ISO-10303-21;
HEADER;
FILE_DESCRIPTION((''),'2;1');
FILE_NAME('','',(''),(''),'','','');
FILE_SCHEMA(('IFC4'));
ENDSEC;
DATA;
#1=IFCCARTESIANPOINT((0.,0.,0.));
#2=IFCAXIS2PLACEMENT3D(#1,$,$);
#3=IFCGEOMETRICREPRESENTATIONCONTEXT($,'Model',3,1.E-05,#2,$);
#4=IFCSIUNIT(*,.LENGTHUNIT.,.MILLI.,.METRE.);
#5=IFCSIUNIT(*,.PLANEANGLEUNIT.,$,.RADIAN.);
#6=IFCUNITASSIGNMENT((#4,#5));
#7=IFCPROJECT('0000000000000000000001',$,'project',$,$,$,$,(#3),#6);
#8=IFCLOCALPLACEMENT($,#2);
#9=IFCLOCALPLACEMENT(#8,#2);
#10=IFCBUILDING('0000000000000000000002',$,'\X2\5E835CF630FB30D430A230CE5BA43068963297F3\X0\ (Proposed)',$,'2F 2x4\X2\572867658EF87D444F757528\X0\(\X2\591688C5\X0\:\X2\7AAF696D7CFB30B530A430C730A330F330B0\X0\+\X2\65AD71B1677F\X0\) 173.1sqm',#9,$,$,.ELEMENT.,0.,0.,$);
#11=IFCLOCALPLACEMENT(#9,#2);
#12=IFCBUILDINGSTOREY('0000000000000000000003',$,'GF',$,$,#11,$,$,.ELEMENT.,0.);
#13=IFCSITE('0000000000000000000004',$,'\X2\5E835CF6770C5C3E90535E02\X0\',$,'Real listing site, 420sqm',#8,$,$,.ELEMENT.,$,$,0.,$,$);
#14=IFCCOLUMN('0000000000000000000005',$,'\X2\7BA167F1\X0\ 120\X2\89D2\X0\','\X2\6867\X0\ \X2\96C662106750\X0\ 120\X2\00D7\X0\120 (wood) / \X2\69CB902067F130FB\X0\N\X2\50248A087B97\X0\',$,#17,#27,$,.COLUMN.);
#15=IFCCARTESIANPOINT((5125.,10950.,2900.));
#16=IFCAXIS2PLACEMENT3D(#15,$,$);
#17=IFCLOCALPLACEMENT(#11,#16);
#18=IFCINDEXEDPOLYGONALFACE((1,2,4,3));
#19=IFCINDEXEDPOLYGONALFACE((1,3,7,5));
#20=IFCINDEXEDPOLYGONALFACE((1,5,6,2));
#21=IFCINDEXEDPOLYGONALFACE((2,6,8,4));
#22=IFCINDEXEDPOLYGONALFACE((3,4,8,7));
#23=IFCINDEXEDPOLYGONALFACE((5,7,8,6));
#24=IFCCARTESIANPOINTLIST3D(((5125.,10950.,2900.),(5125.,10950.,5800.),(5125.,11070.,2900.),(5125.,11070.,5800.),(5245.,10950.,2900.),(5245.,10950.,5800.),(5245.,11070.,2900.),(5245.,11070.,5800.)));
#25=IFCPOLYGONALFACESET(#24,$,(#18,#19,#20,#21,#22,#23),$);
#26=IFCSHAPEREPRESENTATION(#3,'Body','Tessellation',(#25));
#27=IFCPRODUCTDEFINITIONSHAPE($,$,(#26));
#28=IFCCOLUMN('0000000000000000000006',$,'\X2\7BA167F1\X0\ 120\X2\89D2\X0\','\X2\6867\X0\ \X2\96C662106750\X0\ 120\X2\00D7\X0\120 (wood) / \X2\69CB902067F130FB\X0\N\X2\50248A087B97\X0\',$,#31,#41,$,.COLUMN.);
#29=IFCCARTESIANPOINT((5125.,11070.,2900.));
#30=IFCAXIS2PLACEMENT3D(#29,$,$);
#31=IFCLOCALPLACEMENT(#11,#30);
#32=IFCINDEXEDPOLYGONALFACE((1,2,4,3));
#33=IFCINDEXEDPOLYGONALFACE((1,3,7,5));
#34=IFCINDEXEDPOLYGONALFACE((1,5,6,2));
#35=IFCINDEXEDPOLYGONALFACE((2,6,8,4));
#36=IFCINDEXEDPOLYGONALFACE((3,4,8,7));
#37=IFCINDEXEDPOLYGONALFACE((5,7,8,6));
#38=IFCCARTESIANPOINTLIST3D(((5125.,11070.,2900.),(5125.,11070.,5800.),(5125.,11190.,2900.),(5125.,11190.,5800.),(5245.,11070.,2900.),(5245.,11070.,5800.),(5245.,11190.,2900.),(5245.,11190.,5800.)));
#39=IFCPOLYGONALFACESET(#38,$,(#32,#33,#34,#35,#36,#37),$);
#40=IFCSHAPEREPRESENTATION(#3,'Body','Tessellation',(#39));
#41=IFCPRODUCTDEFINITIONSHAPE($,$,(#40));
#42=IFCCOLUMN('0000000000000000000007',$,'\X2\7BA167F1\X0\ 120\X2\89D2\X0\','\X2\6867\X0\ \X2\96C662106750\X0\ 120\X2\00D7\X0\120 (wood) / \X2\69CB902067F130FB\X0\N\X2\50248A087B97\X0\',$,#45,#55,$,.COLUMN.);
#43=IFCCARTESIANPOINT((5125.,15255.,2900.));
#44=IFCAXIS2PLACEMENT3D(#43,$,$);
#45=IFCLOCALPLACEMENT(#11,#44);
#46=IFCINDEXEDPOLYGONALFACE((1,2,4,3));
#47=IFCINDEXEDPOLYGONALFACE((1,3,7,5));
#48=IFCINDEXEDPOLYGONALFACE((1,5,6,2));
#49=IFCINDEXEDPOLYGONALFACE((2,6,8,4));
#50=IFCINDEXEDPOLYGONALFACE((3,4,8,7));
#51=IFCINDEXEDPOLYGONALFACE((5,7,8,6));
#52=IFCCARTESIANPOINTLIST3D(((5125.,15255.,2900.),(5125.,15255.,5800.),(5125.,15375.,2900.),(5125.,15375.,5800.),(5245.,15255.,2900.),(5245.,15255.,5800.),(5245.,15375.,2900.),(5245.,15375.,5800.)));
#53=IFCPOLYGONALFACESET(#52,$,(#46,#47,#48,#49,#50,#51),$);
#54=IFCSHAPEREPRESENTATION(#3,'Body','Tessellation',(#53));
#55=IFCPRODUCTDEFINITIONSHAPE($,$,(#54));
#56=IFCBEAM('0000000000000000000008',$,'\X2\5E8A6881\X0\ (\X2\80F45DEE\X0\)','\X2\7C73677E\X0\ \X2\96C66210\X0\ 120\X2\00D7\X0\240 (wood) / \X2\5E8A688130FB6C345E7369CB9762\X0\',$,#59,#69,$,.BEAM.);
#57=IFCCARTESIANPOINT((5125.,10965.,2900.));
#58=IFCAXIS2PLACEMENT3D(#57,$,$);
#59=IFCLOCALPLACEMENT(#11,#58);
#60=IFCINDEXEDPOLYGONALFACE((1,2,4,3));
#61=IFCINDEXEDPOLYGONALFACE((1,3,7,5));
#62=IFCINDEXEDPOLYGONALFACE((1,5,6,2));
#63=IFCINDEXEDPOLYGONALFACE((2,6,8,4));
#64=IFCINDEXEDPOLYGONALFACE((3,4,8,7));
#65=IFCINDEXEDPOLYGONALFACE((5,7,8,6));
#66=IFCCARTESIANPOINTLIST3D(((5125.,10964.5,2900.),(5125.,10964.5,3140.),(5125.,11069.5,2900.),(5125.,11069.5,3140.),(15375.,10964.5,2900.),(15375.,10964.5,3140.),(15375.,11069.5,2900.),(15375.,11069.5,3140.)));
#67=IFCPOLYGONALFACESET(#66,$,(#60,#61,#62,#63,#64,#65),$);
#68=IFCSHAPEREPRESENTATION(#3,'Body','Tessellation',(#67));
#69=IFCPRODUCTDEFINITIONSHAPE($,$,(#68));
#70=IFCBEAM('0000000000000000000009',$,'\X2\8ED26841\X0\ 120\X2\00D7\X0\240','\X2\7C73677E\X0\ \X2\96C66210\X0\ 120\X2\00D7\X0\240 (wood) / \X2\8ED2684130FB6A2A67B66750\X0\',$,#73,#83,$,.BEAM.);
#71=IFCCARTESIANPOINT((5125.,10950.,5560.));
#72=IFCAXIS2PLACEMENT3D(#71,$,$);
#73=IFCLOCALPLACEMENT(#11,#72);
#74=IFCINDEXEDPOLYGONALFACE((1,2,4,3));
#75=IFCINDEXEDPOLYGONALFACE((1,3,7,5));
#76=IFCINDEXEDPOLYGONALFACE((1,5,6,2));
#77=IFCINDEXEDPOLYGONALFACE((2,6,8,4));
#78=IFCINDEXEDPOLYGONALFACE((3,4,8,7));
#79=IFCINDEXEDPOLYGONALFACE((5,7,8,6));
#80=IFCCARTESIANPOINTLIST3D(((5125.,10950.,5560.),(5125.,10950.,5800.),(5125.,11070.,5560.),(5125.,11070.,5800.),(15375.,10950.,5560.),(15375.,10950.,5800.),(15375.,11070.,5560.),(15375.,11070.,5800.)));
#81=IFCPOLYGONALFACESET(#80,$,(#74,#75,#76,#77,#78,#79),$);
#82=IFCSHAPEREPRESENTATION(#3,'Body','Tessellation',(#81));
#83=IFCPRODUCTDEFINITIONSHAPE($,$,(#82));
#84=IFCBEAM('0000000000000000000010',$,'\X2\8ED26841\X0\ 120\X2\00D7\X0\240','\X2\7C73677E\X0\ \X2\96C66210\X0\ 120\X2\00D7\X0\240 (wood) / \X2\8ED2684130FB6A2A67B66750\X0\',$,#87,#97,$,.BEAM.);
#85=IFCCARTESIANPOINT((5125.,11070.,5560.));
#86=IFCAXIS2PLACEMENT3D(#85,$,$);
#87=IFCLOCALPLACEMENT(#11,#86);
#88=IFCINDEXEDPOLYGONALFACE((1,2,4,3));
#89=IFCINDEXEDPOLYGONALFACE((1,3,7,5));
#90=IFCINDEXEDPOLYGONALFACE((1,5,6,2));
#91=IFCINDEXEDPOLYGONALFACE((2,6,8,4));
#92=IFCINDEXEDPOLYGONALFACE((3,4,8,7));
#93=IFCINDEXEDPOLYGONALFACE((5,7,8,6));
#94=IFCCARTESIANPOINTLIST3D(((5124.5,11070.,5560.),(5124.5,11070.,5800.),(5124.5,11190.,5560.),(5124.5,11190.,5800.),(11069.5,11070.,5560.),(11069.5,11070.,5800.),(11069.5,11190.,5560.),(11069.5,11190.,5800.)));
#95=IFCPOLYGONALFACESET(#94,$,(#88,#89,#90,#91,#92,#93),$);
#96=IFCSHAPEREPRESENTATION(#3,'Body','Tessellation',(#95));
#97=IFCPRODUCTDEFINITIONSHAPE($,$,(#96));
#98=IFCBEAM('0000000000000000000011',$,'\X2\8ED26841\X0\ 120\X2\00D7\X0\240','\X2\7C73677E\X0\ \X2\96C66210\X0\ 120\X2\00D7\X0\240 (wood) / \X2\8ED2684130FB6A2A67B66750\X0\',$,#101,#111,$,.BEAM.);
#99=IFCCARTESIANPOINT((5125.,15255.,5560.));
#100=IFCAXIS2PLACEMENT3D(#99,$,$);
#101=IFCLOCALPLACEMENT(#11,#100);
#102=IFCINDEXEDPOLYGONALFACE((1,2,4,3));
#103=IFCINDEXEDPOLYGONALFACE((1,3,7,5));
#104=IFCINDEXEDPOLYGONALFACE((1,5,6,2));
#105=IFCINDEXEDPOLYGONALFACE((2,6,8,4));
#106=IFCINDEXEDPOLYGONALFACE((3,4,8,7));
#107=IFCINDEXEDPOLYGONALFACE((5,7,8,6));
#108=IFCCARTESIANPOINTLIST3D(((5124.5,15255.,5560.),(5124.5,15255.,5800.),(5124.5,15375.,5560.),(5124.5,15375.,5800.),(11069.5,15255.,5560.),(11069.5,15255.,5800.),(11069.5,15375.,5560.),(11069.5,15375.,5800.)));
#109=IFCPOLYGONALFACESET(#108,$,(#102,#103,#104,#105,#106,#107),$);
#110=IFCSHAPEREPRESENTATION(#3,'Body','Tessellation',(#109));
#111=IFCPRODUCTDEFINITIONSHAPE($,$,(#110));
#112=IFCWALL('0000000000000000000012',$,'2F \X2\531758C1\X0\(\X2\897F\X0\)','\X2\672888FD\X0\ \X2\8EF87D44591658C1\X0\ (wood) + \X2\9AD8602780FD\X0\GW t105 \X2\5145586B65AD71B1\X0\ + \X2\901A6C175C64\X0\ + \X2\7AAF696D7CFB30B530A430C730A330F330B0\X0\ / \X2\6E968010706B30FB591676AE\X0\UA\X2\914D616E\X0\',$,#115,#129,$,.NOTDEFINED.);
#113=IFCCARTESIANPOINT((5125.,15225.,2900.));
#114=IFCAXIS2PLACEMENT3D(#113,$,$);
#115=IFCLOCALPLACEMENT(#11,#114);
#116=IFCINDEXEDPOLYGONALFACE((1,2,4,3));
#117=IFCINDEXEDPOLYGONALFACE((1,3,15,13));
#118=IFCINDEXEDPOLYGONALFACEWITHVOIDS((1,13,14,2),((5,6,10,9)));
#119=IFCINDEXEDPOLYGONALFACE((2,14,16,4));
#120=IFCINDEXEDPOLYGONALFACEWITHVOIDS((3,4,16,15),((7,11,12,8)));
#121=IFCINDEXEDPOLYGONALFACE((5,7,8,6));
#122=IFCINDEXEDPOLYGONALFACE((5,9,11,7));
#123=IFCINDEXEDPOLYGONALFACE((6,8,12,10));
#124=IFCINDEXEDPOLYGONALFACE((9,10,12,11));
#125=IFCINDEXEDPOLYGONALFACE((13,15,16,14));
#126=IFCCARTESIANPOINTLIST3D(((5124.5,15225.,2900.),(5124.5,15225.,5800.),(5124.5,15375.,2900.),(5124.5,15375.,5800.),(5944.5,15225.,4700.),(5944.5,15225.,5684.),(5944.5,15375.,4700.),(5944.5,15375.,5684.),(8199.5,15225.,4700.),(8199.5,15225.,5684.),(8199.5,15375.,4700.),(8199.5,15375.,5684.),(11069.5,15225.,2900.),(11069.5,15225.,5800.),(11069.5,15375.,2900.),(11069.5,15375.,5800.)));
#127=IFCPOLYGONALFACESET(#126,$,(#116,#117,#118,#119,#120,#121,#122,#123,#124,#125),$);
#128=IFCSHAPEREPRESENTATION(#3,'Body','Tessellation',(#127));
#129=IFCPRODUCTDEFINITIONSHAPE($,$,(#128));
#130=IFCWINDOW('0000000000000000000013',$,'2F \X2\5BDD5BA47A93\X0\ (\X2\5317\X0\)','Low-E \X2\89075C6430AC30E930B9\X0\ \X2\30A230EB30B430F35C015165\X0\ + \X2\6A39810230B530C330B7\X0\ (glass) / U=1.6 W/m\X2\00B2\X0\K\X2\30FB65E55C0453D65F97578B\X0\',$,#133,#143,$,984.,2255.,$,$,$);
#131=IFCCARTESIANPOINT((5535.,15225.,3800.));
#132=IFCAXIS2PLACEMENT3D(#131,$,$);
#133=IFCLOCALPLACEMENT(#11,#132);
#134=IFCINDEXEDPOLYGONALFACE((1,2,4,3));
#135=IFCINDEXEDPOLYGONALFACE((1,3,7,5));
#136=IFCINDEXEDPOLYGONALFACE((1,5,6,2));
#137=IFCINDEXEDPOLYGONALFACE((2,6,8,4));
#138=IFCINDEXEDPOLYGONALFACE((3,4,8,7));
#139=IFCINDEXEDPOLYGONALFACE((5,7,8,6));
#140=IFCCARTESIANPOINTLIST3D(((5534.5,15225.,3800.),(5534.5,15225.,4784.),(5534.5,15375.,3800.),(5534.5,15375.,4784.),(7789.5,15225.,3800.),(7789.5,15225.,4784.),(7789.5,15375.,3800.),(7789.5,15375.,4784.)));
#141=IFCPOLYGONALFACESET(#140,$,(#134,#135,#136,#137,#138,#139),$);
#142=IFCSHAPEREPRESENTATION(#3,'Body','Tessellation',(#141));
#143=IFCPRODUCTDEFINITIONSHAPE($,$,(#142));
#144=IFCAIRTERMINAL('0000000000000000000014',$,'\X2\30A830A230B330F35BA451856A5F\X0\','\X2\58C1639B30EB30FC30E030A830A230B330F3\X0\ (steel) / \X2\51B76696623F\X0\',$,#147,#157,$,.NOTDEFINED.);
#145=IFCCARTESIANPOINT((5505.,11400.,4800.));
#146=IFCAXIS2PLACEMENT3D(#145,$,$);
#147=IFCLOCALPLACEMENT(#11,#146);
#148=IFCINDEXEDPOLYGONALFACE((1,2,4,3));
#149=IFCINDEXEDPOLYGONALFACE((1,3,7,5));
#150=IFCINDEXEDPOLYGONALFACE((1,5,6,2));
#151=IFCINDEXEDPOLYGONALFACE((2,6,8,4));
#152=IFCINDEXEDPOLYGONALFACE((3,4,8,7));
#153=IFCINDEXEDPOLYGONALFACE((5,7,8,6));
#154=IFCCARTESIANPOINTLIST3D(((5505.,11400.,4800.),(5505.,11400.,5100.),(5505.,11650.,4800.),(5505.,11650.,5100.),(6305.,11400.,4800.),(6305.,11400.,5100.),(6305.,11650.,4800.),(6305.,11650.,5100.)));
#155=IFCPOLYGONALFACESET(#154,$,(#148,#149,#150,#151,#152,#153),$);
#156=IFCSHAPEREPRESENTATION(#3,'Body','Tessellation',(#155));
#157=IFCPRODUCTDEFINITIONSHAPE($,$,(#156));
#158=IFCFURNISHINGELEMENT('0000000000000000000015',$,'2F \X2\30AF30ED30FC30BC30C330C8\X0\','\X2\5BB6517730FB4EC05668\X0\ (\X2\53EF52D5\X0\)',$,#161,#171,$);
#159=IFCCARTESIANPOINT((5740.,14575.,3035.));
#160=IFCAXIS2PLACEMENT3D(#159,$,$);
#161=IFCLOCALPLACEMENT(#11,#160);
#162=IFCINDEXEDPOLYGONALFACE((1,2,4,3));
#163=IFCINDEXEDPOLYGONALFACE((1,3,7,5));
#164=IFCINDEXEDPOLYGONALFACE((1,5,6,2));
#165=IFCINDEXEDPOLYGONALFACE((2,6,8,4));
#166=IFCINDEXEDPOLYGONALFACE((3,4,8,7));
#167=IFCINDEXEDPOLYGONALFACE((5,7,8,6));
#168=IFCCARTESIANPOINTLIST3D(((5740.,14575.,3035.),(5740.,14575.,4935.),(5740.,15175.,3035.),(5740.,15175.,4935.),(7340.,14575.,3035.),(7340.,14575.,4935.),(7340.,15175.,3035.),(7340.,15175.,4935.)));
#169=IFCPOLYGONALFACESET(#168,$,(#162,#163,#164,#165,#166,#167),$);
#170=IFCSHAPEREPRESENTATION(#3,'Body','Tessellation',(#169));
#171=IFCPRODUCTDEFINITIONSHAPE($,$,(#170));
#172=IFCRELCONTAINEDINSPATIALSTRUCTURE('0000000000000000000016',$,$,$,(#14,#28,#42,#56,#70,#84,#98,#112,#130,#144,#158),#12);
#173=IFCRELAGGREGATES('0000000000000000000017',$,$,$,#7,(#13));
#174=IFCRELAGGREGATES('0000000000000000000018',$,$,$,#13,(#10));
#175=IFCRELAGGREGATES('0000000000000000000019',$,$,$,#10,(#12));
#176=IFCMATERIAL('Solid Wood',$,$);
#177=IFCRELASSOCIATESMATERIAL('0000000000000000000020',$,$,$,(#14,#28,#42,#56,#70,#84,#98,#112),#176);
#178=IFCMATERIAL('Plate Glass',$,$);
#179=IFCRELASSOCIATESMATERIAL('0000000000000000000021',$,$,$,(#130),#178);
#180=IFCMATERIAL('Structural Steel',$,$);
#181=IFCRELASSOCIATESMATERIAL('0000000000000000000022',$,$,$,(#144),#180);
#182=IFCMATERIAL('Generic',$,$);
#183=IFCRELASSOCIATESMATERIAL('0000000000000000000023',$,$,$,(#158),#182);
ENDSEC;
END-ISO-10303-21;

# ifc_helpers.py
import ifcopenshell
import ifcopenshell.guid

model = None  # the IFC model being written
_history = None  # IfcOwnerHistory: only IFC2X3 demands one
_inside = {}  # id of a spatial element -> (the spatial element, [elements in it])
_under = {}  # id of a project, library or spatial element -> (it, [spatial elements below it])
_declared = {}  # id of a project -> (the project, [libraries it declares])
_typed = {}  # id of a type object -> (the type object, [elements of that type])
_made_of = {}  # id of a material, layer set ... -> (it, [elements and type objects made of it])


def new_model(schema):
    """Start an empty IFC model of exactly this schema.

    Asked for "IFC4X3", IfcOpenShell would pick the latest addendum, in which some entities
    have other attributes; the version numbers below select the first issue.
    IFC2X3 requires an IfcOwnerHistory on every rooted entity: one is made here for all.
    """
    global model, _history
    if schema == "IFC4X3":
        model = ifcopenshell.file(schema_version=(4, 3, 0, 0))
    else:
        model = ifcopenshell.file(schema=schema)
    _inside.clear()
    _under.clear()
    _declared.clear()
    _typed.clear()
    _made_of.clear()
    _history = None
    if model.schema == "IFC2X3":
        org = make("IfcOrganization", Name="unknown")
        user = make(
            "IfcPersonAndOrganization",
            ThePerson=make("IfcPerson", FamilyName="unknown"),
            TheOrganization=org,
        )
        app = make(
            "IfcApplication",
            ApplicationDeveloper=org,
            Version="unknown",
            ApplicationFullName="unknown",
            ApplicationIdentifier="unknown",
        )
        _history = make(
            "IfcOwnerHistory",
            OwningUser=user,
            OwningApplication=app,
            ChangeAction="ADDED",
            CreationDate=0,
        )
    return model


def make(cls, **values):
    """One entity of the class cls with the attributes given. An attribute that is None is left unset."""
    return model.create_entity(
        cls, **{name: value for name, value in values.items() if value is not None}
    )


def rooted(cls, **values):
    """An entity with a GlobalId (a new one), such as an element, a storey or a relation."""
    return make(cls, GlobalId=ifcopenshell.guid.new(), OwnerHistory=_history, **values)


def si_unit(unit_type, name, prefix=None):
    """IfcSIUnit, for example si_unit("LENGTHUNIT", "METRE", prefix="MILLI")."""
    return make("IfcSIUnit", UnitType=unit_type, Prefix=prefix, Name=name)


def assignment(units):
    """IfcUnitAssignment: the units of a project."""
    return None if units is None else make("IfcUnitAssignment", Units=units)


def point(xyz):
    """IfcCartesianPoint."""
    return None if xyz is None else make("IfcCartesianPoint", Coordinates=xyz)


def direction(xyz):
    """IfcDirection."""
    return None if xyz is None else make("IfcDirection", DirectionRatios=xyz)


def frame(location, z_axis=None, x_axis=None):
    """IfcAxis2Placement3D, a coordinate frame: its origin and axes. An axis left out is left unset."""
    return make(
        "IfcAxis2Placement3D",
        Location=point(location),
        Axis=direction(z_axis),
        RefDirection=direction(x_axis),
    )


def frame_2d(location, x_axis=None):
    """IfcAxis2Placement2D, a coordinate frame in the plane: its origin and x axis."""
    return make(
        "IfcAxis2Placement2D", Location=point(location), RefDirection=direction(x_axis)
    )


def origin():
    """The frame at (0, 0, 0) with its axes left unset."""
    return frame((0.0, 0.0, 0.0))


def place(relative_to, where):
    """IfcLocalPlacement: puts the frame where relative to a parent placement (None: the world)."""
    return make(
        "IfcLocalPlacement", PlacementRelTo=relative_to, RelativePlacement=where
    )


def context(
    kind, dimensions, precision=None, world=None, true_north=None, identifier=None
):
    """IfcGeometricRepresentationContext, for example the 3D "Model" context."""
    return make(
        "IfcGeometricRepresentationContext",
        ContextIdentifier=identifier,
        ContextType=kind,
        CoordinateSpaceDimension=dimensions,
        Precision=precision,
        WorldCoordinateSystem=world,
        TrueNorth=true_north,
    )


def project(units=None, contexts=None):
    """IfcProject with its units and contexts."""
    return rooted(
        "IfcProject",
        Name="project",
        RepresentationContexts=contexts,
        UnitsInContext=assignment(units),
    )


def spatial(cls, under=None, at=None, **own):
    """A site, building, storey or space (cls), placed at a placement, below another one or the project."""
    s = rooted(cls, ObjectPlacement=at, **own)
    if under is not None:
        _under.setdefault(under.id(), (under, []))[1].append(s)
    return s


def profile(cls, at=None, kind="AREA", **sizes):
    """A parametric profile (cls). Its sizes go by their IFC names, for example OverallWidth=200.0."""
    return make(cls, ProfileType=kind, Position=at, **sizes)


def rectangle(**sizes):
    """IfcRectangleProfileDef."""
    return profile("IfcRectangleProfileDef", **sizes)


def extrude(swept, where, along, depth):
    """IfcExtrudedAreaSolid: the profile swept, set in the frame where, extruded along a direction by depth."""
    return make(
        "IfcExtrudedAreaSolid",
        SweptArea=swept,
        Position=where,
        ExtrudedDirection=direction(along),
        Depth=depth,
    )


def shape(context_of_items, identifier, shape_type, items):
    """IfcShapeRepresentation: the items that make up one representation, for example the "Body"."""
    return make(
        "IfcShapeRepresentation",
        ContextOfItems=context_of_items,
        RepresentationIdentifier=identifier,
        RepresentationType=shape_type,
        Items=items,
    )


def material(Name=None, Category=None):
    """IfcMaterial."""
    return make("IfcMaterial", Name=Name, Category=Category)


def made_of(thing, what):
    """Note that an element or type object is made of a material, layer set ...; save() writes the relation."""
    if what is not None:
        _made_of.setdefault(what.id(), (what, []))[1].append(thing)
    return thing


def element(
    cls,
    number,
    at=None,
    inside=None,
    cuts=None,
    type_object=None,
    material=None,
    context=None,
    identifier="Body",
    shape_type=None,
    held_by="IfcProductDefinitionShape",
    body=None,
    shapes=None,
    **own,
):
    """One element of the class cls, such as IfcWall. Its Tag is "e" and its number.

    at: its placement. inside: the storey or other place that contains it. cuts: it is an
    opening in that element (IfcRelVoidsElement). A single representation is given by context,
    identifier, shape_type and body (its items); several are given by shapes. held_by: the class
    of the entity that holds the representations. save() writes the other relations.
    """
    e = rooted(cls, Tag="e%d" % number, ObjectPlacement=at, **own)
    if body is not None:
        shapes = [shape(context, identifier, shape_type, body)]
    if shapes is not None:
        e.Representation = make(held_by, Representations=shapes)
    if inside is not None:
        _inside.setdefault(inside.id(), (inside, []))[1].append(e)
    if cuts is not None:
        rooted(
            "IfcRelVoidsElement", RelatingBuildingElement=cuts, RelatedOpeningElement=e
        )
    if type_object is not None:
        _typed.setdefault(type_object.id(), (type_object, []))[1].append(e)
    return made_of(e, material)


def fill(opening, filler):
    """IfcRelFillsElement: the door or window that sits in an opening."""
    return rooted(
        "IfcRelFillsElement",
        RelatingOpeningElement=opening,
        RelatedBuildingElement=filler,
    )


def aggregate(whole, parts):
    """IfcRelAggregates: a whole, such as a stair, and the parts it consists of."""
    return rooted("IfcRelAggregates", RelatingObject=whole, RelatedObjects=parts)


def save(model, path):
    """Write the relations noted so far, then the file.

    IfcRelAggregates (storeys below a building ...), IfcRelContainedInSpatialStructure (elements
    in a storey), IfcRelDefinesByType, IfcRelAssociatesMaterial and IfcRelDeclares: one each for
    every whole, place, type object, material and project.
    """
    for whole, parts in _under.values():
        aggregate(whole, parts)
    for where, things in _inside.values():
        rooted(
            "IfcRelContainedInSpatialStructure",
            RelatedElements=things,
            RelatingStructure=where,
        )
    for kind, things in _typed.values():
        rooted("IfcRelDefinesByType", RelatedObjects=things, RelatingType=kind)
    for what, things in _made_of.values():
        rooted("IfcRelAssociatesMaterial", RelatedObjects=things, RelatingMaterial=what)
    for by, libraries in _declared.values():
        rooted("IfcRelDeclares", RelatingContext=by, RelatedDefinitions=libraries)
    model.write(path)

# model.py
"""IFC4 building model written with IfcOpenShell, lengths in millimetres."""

from ifc_helpers import new_model, si_unit, frame, frame_2d, origin, place, context, project, spatial, rectangle, extrude, material, element, fill, save


model = new_model("IFC4")

# Units and contexts
model_context = context("Model", 3, precision=1e-05, world=origin())
ifc_project = project(units=[si_unit("LENGTHUNIT", "METRE", prefix="MILLI"), si_unit("PLANEANGLEUNIT", "RADIAN")], contexts=[model_context])

# Site, building, storey
site_placement = place(None, origin())
site = spatial("IfcSite", under=ifc_project, at=site_placement, Name="広島県尾道市", ObjectType="Real listing site, 420sqm", CompositionType="ELEMENT", RefElevation=0.0)
building_placement = place(site_placement, origin())
building = spatial("IfcBuilding", under=site, at=building_placement, Name="広島・ピアノ室と防音 (Proposed)", ObjectType="2F 2x4在来軸組併用(外装:窯業系サイディング+断熱板) 173.1sqm", CompositionType="ELEMENT", ElevationOfRefHeight=0.0, ElevationOfTerrain=0.0)
storey_placement = place(building_placement, origin())
storey = spatial("IfcBuildingStorey", under=building, at=storey_placement, Name="GF", CompositionType="ELEMENT", Elevation=0.0)

# Columns
ifc_material_1 = material(Name="Solid Wood")
column_1_placement = place(storey_placement, frame((5125.0, 10950.0, 2900.0)))
element("IfcColumn", 1, at=column_1_placement, inside=storey, material=ifc_material_1, Name="管柱 120角", Description="桧 集成材 120×120 (wood) / 構造柱・N値計算", PredefinedType="COLUMN", context=model_context, shape_type="SweptSolid", body=[
    extrude(rectangle(XDim=120.0, YDim=120.0, at=frame_2d((60.0, 60.0))), frame((5125.0, 10950.0, 2900.0)), (0.0, 0.0, 1.0), 2900.0),
])
column_2_placement = place(storey_placement, frame((5125.0, 11070.0, 2900.0)))
element("IfcColumn", 2, at=column_2_placement, inside=storey, material=ifc_material_1, Name="管柱 120角", Description="桧 集成材 120×120 (wood) / 構造柱・N値計算", PredefinedType="COLUMN", context=model_context, shape_type="SweptSolid", body=[
    extrude(rectangle(XDim=120.0, YDim=120.0, at=frame_2d((60.0, 60.0))), frame((5125.0, 11070.0, 2900.0)), (0.0, 0.0, 1.0), 2900.0),
])
column_3_placement = place(storey_placement, frame((5125.0, 15255.0, 2900.0)))
element("IfcColumn", 3, at=column_3_placement, inside=storey, material=ifc_material_1, Name="管柱 120角", Description="桧 集成材 120×120 (wood) / 構造柱・N値計算", PredefinedType="COLUMN", context=model_context, shape_type="SweptSolid", body=[
    extrude(rectangle(XDim=120.0, YDim=120.0, at=frame_2d((60.0, 60.0))), frame((5125.0, 15255.0, 2900.0)), (0.0, 0.0, 1.0), 2900.0),
])

# Beams
beam_1_placement = place(storey_placement, frame((5125.0, 10965.0, 2900.0)))
element("IfcBeam", 4, at=beam_1_placement, inside=storey, material=ifc_material_1, Name="床梁 (胴差)", Description="米松 集成 120×240 (wood) / 床梁・水平構面", PredefinedType="BEAM", context=model_context, shape_type="SweptSolid", body=[
    extrude(rectangle(XDim=10250.0, YDim=105.0, at=frame_2d((5125.0, 52.0))), frame((5125.0, 10965.0, 2900.0)), (0.0, 0.0, 1.0), 240.0),
])
beam_2_placement = place(storey_placement, frame((5125.0, 10950.0, 5560.0)))
element("IfcBeam", 5, at=beam_2_placement, inside=storey, material=ifc_material_1, Name="軒桁 120×240", Description="米松 集成 120×240 (wood) / 軒桁・横架材", PredefinedType="BEAM", context=model_context, shape_type="SweptSolid", body=[
    extrude(rectangle(XDim=10250.0, YDim=120.0, at=frame_2d((5125.0, 60.0))), frame((5125.0, 10950.0, 5560.0)), (0.0, 0.0, 1.0), 240.0),
])
beam_3_placement = place(storey_placement, frame((5125.0, 11070.0, 5560.0)))
element("IfcBeam", 6, at=beam_3_placement, inside=storey, material=ifc_material_1, Name="軒桁 120×240", Description="米松 集成 120×240 (wood) / 軒桁・横架材", PredefinedType="BEAM", context=model_context, shape_type="SweptSolid", body=[
    extrude(rectangle(XDim=5945.0, YDim=120.0, at=frame_2d((2972.0, 60.0))), frame((5125.0, 11070.0, 5560.0)), (0.0, 0.0, 1.0), 240.0),
])
beam_4_placement = place(storey_placement, frame((5125.0, 15255.0, 5560.0)))
element("IfcBeam", 7, at=beam_4_placement, inside=storey, material=ifc_material_1, Name="軒桁 120×240", Description="米松 集成 120×240 (wood) / 軒桁・横架材", PredefinedType="BEAM", context=model_context, shape_type="SweptSolid", body=[
    extrude(rectangle(XDim=5945.0, YDim=120.0, at=frame_2d((2972.0, 60.0))), frame((5125.0, 15255.0, 5560.0)), (0.0, 0.0, 1.0), 240.0),
])

# Wall, opening, window
wall_1_placement = place(storey_placement, frame((5125.0, 15225.0, 2900.0)))
wall_1 = element("IfcWall", 8, at=wall_1_placement, inside=storey, material=ifc_material_1, Name="2F 北壁(西)", Description="木製 軸組外壁 (wood) + 高性能GW t105 充填断熱 + 通気層 + 窯業系サイディング / 準耐火・外皮UA配慮", PredefinedType="NOTDEFINED", context=model_context, shape_type="SweptSolid", body=[
    extrude(rectangle(XDim=5945.0, YDim=150.0, at=frame_2d((2972.0, 75.0))), frame((5125.0, 15225.0, 2900.0)), (0.0, 0.0, 1.0), 2900.0),
])
opening_placement = place(storey_placement, frame((5535.0, 15225.0, 3800.0)))
opening = element("IfcOpeningElement", 9, at=opening_placement, cuts=wall_1, PredefinedType="NOTDEFINED", context=model_context, shape_type="SweptSolid", body=[
    extrude(rectangle(XDim=2255.0, YDim=150.0, at=frame_2d((1127.0, 75.0))), frame((5535.0, 15225.0, 3800.0)), (0.0, 0.0, 1.0), 984.0),
])
ifc_material_2 = material(Name="Plate Glass")
window_placement = place(storey_placement, frame((5535.0, 15225.0, 3800.0)))
window = element("IfcWindow", 10, at=window_placement, inside=storey, material=ifc_material_2, Name="2F 寝室窓 (北)", Description="Low-E 複層ガラス アルゴン封入 + 樹脂サッシ (glass) / U=1.6 W/m²K・日射取得型", OverallHeight=984.0, OverallWidth=2255.0, context=model_context, shape_type="SweptSolid", body=[
    extrude(rectangle(XDim=2255.0, YDim=150.0, at=frame_2d((1127.0, 75.0))), frame((5535.0, 15225.0, 3800.0)), (0.0, 0.0, 1.0), 984.0),
])
fill(opening, window)

# Shared definitions
ifc_material_3 = material(Name="Structural Steel")

# Shared definitions
ifc_material_4 = material(Name="Generic")

# Air terminal
air_terminal_placement = place(storey_placement, frame((5505.0, 11400.0, 4800.0)))
element("IfcAirTerminal", 11, at=air_terminal_placement, inside=storey, material=ifc_material_3, Name="エアコン室内機", Description="壁掛ルームエアコン (steel) / 冷暖房", PredefinedType="NOTDEFINED", context=model_context, shape_type="SweptSolid", body=[
    extrude(rectangle(XDim=800.0, YDim=250.0, at=frame_2d((400.0, 125.0))), frame((5505.0, 11400.0, 4800.0)), (0.0, 0.0, 1.0), 300.0),
])

# Furnishing element
furnishing_placement = place(storey_placement, frame((5740.0, 14575.0, 3035.0)))
element("IfcFurnishingElement", 12, at=furnishing_placement, inside=storey, material=ifc_material_4, Name="2F クローゼット", Description="家具・什器 (可動)", context=model_context, shape_type="SweptSolid", body=[
    extrude(rectangle(XDim=1600.0, YDim=600.0, at=frame_2d((800.0, 300.0))), frame((5740.0, 14575.0, 3035.0)), (0.0, 0.0, 1.0), 1900.0),
])

save(model, "model.ifc")
